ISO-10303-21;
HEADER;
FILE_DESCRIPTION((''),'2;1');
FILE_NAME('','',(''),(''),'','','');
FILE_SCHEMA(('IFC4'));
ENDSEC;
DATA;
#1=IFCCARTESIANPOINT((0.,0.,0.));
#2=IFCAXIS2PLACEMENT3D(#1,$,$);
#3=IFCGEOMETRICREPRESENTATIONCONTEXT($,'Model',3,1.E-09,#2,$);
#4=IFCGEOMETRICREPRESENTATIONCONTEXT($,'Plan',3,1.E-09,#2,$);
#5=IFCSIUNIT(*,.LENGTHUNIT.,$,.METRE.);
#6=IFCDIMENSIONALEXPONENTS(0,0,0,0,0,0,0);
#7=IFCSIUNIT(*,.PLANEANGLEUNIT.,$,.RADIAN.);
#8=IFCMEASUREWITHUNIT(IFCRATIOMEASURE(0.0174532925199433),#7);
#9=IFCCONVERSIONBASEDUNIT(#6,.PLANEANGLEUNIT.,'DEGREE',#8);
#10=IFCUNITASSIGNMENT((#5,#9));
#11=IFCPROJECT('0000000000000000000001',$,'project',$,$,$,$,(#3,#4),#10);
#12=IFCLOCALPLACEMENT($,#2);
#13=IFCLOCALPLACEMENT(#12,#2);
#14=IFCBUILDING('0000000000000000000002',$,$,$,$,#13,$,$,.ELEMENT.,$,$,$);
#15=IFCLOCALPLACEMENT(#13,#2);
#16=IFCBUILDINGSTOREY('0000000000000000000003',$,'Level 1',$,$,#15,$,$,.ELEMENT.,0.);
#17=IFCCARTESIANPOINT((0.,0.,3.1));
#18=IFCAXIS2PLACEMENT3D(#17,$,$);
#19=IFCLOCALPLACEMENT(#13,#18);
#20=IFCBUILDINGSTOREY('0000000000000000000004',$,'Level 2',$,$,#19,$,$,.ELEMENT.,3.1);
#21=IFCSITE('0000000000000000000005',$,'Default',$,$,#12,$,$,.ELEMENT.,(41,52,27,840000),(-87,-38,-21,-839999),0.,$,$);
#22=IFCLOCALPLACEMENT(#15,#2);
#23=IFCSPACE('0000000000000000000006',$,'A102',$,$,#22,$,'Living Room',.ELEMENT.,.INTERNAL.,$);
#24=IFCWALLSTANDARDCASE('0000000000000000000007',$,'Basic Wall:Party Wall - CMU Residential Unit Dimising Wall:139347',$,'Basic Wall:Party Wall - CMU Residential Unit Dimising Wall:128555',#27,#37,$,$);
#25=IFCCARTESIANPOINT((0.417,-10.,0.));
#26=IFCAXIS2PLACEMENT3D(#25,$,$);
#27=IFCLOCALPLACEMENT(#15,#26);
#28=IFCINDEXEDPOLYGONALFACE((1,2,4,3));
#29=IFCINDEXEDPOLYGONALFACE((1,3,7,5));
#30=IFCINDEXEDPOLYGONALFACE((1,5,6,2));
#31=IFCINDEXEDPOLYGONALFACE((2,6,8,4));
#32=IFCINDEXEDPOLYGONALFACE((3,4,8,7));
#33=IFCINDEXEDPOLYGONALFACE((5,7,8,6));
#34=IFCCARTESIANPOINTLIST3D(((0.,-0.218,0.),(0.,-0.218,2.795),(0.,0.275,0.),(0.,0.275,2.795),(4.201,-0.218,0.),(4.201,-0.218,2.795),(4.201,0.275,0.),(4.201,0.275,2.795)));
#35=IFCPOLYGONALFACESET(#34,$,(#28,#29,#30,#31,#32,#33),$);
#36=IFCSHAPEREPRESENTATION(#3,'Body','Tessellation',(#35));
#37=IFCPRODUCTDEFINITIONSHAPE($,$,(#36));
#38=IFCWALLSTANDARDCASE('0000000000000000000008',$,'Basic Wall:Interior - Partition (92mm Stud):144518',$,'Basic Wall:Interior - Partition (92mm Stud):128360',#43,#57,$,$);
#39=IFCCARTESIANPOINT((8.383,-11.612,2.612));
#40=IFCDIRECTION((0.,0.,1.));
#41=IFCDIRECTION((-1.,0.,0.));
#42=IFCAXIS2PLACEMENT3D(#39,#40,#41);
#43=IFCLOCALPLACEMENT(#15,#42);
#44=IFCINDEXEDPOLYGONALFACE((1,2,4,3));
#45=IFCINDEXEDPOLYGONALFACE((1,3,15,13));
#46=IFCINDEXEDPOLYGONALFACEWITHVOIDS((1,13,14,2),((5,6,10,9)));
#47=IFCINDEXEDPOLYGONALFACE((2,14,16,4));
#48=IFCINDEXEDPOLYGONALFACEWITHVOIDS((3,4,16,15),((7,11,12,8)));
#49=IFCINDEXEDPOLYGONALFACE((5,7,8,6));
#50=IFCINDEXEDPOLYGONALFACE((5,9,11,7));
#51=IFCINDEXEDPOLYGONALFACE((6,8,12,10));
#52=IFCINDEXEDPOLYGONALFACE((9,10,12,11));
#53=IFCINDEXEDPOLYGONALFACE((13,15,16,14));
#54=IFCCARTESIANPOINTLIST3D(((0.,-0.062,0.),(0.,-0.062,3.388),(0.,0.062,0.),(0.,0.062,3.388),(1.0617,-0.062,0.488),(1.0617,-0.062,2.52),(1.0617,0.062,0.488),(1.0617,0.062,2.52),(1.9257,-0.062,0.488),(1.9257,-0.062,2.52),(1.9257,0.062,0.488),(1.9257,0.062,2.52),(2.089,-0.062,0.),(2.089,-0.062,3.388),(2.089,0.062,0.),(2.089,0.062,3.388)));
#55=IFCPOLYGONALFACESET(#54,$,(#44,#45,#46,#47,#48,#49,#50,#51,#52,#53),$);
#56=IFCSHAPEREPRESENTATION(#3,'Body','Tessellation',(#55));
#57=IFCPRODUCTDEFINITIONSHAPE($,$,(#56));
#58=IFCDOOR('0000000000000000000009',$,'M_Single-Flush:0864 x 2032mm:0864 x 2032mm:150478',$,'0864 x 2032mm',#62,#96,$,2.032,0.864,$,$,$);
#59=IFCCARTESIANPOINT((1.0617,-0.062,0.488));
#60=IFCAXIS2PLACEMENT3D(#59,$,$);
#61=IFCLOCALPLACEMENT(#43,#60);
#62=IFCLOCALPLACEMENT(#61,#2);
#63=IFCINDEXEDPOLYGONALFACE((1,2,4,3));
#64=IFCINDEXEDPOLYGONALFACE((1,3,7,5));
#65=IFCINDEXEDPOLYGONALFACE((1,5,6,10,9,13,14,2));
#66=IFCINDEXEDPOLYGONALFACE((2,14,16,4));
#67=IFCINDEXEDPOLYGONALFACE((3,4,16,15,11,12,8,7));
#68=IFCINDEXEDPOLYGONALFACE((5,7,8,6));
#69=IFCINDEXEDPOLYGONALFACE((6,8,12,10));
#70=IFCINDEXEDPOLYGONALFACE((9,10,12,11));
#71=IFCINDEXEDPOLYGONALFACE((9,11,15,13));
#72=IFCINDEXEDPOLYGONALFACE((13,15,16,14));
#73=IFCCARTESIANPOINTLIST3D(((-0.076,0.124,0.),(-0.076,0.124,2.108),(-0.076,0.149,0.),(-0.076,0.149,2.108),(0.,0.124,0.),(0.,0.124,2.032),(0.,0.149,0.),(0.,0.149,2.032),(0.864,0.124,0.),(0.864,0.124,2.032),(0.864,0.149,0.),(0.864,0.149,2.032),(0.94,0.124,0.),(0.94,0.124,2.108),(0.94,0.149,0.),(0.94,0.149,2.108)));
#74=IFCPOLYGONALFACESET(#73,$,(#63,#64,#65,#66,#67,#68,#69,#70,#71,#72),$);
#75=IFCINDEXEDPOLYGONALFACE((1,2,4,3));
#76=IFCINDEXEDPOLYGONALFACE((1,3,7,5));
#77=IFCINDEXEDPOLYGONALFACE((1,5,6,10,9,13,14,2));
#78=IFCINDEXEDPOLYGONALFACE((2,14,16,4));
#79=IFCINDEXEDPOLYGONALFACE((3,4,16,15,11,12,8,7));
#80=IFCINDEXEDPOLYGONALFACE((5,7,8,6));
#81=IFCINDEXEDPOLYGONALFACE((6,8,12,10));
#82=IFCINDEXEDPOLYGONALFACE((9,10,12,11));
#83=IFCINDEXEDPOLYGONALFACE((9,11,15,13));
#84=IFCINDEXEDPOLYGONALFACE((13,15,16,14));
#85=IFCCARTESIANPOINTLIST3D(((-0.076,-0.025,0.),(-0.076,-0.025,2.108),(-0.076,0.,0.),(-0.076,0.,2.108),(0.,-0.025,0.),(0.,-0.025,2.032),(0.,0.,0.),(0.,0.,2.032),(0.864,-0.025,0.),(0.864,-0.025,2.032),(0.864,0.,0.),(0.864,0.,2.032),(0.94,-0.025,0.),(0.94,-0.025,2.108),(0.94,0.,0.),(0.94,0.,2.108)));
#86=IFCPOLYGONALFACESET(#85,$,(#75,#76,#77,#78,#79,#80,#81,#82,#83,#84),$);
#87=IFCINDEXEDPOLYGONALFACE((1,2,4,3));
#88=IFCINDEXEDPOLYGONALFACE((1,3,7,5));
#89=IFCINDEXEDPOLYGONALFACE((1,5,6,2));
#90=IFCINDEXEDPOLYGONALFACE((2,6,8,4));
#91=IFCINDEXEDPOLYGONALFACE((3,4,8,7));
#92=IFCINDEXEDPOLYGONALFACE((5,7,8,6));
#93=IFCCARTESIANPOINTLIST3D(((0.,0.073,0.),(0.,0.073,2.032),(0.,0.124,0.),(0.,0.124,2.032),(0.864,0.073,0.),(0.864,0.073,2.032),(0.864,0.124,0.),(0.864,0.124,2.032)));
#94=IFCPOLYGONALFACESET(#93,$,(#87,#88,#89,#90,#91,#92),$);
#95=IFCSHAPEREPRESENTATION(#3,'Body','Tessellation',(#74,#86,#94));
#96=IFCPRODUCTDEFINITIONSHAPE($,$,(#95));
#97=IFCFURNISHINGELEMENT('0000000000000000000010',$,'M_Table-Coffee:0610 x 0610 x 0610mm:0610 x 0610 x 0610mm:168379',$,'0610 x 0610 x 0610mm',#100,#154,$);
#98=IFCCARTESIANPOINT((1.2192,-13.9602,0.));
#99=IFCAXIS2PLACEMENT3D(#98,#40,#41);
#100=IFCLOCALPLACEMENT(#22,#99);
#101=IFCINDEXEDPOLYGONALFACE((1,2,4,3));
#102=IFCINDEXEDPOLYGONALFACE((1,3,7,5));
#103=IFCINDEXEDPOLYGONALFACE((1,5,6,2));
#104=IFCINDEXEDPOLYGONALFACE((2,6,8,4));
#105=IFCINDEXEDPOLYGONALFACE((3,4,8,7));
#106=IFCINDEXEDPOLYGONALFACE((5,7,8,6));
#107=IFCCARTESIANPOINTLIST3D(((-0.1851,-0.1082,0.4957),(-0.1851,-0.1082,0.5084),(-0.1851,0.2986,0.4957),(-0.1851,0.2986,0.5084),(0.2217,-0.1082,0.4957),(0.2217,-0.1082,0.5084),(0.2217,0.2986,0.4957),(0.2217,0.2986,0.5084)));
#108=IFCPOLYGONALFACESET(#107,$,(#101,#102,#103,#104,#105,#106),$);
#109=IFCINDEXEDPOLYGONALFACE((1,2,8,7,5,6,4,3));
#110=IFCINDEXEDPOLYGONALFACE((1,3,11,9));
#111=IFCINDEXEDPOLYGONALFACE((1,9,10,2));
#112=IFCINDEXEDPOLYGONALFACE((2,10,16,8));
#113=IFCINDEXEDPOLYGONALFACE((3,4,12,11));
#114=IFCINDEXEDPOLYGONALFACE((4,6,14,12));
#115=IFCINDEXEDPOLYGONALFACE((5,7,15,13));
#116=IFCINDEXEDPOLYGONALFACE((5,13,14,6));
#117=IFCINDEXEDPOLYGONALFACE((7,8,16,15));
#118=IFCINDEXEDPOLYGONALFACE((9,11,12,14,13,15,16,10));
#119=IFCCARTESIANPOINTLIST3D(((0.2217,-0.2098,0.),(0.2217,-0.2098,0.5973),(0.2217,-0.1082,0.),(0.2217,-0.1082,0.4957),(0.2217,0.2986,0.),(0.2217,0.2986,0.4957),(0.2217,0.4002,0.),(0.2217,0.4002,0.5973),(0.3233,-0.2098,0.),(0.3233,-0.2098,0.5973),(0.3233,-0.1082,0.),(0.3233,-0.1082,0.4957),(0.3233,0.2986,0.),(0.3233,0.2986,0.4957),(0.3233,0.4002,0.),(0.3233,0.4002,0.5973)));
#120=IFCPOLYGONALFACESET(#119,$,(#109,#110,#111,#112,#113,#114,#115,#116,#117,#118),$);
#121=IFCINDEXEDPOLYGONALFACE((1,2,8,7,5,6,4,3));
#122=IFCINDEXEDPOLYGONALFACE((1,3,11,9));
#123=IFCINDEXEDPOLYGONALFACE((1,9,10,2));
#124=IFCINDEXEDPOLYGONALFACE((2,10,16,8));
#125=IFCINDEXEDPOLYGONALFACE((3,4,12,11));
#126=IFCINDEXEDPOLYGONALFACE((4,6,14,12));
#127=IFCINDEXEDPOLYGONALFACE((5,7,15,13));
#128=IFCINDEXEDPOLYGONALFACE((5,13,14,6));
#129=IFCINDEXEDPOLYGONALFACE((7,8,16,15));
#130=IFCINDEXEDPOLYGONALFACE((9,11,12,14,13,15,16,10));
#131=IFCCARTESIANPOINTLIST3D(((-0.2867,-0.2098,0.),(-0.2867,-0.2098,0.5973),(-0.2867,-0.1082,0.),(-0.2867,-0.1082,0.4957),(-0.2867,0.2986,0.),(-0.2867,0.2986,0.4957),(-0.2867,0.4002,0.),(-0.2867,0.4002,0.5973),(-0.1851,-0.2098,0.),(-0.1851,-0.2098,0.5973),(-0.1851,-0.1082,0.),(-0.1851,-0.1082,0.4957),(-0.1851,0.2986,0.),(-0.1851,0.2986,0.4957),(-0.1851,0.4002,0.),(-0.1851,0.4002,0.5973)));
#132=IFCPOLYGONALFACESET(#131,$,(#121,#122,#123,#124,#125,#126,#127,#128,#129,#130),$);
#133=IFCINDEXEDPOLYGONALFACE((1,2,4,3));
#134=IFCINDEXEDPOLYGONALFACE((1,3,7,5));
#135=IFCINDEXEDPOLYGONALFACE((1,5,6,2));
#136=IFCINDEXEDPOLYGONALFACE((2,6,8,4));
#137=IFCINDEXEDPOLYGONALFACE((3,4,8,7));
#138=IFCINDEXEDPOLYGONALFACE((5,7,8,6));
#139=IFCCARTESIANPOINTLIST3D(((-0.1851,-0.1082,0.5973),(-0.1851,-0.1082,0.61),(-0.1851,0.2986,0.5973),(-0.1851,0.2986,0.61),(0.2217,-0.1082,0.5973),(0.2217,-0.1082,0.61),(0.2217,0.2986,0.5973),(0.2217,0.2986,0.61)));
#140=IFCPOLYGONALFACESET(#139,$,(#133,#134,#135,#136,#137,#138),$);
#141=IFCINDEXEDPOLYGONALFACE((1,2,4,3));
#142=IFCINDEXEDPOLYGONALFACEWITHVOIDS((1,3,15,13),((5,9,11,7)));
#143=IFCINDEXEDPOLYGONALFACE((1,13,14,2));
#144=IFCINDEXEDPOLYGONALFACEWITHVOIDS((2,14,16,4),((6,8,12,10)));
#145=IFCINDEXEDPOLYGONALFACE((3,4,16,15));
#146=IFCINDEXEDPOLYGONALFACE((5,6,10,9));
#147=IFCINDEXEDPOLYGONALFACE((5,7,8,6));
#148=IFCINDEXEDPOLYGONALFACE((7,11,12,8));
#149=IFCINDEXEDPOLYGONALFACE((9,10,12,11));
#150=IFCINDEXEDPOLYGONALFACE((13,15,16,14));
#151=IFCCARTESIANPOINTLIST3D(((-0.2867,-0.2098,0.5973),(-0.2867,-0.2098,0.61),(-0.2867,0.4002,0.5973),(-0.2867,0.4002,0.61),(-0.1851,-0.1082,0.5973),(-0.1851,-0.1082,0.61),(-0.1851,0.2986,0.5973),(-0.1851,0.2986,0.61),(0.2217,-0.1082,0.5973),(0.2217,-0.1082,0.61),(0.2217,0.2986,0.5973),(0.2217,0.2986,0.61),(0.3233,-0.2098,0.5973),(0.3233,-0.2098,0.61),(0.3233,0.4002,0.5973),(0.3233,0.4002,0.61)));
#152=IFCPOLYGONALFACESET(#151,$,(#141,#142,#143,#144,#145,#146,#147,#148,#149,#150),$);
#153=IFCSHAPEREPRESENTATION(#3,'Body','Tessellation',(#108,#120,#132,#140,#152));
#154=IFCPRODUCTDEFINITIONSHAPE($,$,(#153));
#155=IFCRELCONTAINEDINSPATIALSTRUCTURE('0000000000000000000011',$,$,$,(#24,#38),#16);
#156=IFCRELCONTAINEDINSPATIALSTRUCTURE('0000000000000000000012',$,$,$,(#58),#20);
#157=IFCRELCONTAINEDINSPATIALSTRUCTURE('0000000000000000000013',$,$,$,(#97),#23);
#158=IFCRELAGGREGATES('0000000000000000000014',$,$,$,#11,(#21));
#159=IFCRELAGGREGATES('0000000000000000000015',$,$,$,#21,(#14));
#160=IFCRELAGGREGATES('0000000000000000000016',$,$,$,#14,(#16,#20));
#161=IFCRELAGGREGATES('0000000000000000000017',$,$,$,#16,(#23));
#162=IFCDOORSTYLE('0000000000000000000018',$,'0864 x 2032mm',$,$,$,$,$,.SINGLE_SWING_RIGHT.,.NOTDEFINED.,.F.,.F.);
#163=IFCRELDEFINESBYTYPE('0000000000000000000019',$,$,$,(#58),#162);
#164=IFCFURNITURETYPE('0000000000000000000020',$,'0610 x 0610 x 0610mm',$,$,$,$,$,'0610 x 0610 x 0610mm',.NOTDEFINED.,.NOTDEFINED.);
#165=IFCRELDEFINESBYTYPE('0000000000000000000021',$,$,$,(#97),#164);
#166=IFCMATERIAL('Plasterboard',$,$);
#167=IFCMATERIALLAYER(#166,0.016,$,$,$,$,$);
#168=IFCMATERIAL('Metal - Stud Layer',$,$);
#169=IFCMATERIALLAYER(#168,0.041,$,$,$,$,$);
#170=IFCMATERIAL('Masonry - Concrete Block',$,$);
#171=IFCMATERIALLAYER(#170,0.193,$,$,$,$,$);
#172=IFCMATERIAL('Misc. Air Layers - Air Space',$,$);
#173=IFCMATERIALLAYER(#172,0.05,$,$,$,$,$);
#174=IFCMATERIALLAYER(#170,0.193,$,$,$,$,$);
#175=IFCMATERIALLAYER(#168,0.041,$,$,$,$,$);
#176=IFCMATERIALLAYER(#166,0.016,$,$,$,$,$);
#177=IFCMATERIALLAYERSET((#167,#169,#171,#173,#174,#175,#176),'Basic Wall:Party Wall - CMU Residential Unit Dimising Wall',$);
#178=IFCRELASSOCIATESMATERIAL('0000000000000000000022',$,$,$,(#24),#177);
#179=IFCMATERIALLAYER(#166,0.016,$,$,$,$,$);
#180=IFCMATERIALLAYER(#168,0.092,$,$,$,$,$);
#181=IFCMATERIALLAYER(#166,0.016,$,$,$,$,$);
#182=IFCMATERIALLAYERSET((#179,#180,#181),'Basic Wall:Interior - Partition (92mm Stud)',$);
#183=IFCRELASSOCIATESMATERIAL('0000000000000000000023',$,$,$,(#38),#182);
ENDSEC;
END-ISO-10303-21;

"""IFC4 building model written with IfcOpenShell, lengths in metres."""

from ifc_helpers import new_model, entity, si_unit, converted_unit, frame, frame_2d, origin, origin_2d_with_axis, place, context, project, spatial, polyline, rectangle, outline, extrude, clip, bounded_halfspace, source, transform, mapped, material, layer, layer_set, layer_usage, type_object, type_shapes, element, fill, save


model = new_model("IFC4")

# Units and contexts
model_context = context("Model", 3, precision=1e-09, world=origin())
plan_context = context("Plan", 3, precision=1e-09, world=origin())
ifc_project = project(units=[si_unit("LENGTHUNIT", "METRE"), converted_unit("PLANEANGLEUNIT", "DEGREE", entity("IfcRatioMeasure", 0.0174532925199433), si_unit("PLANEANGLEUNIT", "RADIAN"), dimensions=[0, 0, 0, 0, 0, 0, 0])], contexts=[model_context, plan_context])

# Site, building, storey
site_placement = place(None, origin())
site = spatial("IfcSite", under=ifc_project, at=site_placement, Name="Default", CompositionType="ELEMENT", RefLatitude=(41, 52, 27, 840000), RefLongitude=(-87, -38, -21, -839999), RefElevation=0.0)
building_placement = place(site_placement, origin())
building = spatial("IfcBuilding", under=site, at=building_placement, CompositionType="ELEMENT")
storey_1_placement = place(building_placement, origin())
storey_1 = spatial("IfcBuildingStorey", under=building, at=storey_1_placement, Name="Level 1", CompositionType="ELEMENT", Elevation=0.0)

# Shared definitions
ifc_material_1 = material(Name="Metal - Stud Layer")
ifc_material_2 = material(Name="Plasterboard")
ifc_layer_1 = layer(ifc_material_2, 0.016)
ifc_layer_2 = layer(ifc_material_1, 0.041)
ifc_material_3 = material(Name="Masonry - Concrete Block")
ifc_layer_3 = layer(ifc_material_3, 0.193)
ifc_material_4 = material(Name="Misc. Air Layers - Air Space")
ifc_layer_4 = layer(ifc_material_4, 0.05)
ifc_layer_5 = layer(ifc_material_3, 0.193)
ifc_layer_6 = layer(ifc_material_1, 0.041)
ifc_layer_7 = layer(ifc_material_2, 0.016)
ifc_layer_set_1 = layer_set([ifc_layer_1, ifc_layer_2, ifc_layer_3, ifc_layer_4, ifc_layer_5, ifc_layer_6, ifc_layer_7], Name="Basic Wall:Party Wall - CMU Residential Unit Dimising Wall")

# Wall
ifc_layer_8 = layer(ifc_material_2, 0.016)
ifc_layer_9 = layer(ifc_material_1, 0.092)
ifc_layer_10 = layer(ifc_material_2, 0.016)
ifc_layer_set_2 = layer_set([ifc_layer_8, ifc_layer_9, ifc_layer_10], Name="Basic Wall:Interior - Partition (92mm Stud)")
ifc_layer_usage_1 = layer_usage(ifc_layer_set_1, "AXIS2", "NEGATIVE", 0.275)
wall_1_placement = place(storey_1_placement, frame((0.417, -10.0, 0.0)))
element("IfcWallStandardCase", 1, at=wall_1_placement, inside=storey_1, material=ifc_layer_usage_1, Name="Basic Wall:Party Wall - CMU Residential Unit Dimising Wall:139347", ObjectType="Basic Wall:Party Wall - CMU Residential Unit Dimising Wall:128555", context=model_context, shape_type="Clipping", body=[
    clip(clip(extrude(rectangle(XDim=4.201, YDim=0.55, at=frame_2d((2.1005, 0.0), x_axis=(-1.0, 0.0))), origin(), (0.0, 0.0, 1.0), 2.795), bounded_halfspace(frame((0.0, -0.218, 0.0), z_axis=(0.0, 1.0, 0.0), x_axis=(-1.0, 0.0, 0.0)), True, frame((0.0, -0.218, 0.0), z_axis=(0.0, 1.0, 0.0), x_axis=(-1.0, 0.0, 0.0)), polyline([(0.0, 0.0), (0.0, 2.795), (-4.201, 2.795), (-4.201, 0.0), (0.0, 0.0)]))), bounded_halfspace(frame((4.201, 0.275, 0.0), z_axis=(-1.0, 0.0, 0.0), x_axis=(0.0, -1.0, 0.0)), True, frame((4.201, 0.275, 0.0), z_axis=(-1.0, 0.0, 0.0), x_axis=(0.0, -1.0, 0.0)), polyline([(0.0, 0.0), (0.493, 0.0), (0.493, 2.795), (0.0, 2.795), (0.0, 0.0)]))),
])

# Wall, opening
ifc_layer_usage_2 = layer_usage(ifc_layer_set_2, "AXIS2", "NEGATIVE", 0.062)
wall_2_placement = place(storey_1_placement, frame((8.383, -11.612, 2.612), z_axis=(0.0, 0.0, 1.0), x_axis=(-1.0, 0.0, 0.0)))
wall_2 = element("IfcWallStandardCase", 2, at=wall_2_placement, inside=storey_1, material=ifc_layer_usage_2, Name="Basic Wall:Interior - Partition (92mm Stud):144518", ObjectType="Basic Wall:Interior - Partition (92mm Stud):128360", context=model_context, shape_type="SweptSolid", body=[
    extrude(rectangle(XDim=2.089, YDim=0.124, at=frame_2d((1.0445, 0.0), x_axis=(-1.0, 0.0))), origin(), (0.0, 0.0, 1.0), 3.388),
])
opening_1_placement = place(wall_2_placement, frame((1.0617, -0.062, 0.488)))
opening_1 = element("IfcOpeningElement", 3, at=opening_1_placement, cuts=wall_2, ObjectType="Opening", context=model_context, shape_type="SweptSolid", body=[
    extrude(rectangle(XDim=0.864, YDim=2.032, at=frame_2d((1.016, 0.432), x_axis=(0.0, 1.0))), frame((0.0, 0.0, 0.0), z_axis=(0.0, 1.0, 0.0), x_axis=(0.0, 0.0, 1.0)), (0.0, 0.0, 1.0), 0.124),
])

# Shared definitions
storey_2_placement = place(building_placement, frame((0.0, 0.0, 3.1)))
storey_2 = spatial("IfcBuildingStorey", under=building, at=storey_2_placement, Name="Level 2", CompositionType="ELEMENT", Elevation=3.1)

# Door
door_style_1 = type_object("IfcDoorStyle", Name="0864 x 2032mm", ConstructionType="NOTDEFINED", OperationType="SINGLE_SWING_RIGHT", ParameterTakesPrecedence=False, Sizeable=False)
shared_shape_1 = source(origin(), model_context, "Body", "SweptSolid", [
    extrude(outline(polyline([(-0.508, -1.073), (0.508, -1.073), (0.508, 1.035), (0.432, 1.035), (0.432, -0.997), (-0.432, -0.997), (-0.432, 1.035), (-0.508, 1.035), (-0.508, -1.073)])), frame((0.432, 0.124, 1.035), z_axis=(0.0, 1.0, 0.0), x_axis=(1.0, 0.0, 0.0)), (0.0, 0.0, 1.0), 0.025),
    extrude(outline(polyline([(-1.073, -0.508), (1.035, -0.508), (1.035, -0.432), (-0.997, -0.432), (-0.997, 0.432), (1.035, 0.432), (1.035, 0.508), (-1.073, 0.508), (-1.073, -0.508)])), frame((0.432, -0.025, 1.035), z_axis=(0.0, 1.0, 0.0), x_axis=(0.0, 0.0, -1.0)), (0.0, 0.0, 1.0), 0.025),
    extrude(rectangle(XDim=0.051, YDim=0.864, at=origin_2d_with_axis()), frame((0.432, 0.0985, 0.0), z_axis=(0.0, 0.0, 1.0), x_axis=(0.0, 1.0, 0.0)), (0.0, 0.0, 1.0), 2.032),
])
type_shapes(door_style_1, [shared_shape_1])
door_1_placement = place(opening_1_placement, origin())
door_1 = element("IfcDoor", 4, at=door_1_placement, inside=storey_2, type_object=door_style_1, Name="M_Single-Flush:0864 x 2032mm:0864 x 2032mm:150478", ObjectType="0864 x 2032mm", OverallHeight=2.032, OverallWidth=0.864, context=model_context, shape_type="MappedRepresentation", body=[
    mapped(shared_shape_1, transform((0.0, 0.0, 0.0), scale=1.0)),
])
fill(opening_1, door_1)

# Shared definitions
space_1_placement = place(storey_1_placement, origin())
space_1 = spatial("IfcSpace", under=storey_1, at=space_1_placement, Name="A102", LongName="Living Room", CompositionType="ELEMENT", PredefinedType="INTERNAL")

# Furnishing element
furniture_type_1 = type_object("IfcFurnitureType", Name="0610 x 0610 x 0610mm", ElementType="0610 x 0610 x 0610mm", AssemblyPlace="NOTDEFINED")
shared_shape_2 = source(origin(), model_context, "Body", "SweptSolid", [
    extrude(rectangle(XDim=0.4068, YDim=0.4068, at=origin_2d_with_axis()), frame((0.0183, 0.0952, 0.4957), z_axis=(0.0, 0.0, 1.0), x_axis=(-1.0, 0.0, 0.0)), (0.0, 0.0, 1.0), 0.0127),
    extrude(outline(polyline([(-0.2732, -0.305), (0.324, -0.305), (0.324, 0.305), (-0.2732, 0.305), (-0.2732, 0.2034), (0.2225, 0.2034), (0.2225, -0.2034), (-0.2732, -0.2034), (-0.2732, -0.305)])), frame((0.2217, 0.0952, 0.2732), z_axis=(1.0, 0.0, 0.0), x_axis=(0.0, 0.0, 1.0)), (0.0, 0.0, 1.0), 0.1016),
    extrude(outline(polyline([(-0.305, -0.3241), (0.305, -0.3241), (0.305, 0.2733), (0.2034, 0.2733), (0.2034, -0.2224), (-0.2034, -0.2224), (-0.2034, 0.2733), (-0.305, 0.2733), (-0.305, -0.3241)])), frame((-0.2867, 0.0952, 0.2733), z_axis=(1.0, 0.0, 0.0), x_axis=(0.0, -1.0, 0.0)), (0.0, 0.0, 1.0), 0.1016),
    extrude(rectangle(XDim=0.4068, YDim=0.4068, at=origin_2d_with_axis()), frame((0.0183, 0.0952, 0.5973), z_axis=(0.0, 0.0, 1.0), x_axis=(-1.0, 0.0, 0.0)), (0.0, 0.0, 1.0), 0.0127),
    extrude(outline(polyline([(-0.305, -0.305), (0.305, -0.305), (0.305, 0.305), (-0.305, 0.305), (-0.305, -0.305)]), holes=[polyline([(-0.2034, -0.2034), (-0.2034, 0.2034), (0.2034, 0.2034), (0.2034, -0.2034), (-0.2034, -0.2034)])]), frame((0.0183, 0.0952, 0.5973), z_axis=(0.0, 0.0, 1.0), x_axis=(-1.0, 0.0, 0.0)), (0.0, 0.0, 1.0), 0.0127),
])
type_shapes(furniture_type_1, [shared_shape_2])
for number, where, z_axis, x_axis, name in (
    (5, (1.2192, -13.9602, 0.0), (0.0, 0.0, 1.0), (-1.0, 0.0, 0.0), "M_Table-Coffee:0610 x 0610 x 0610mm:0610 x 0610 x 0610mm:168379"),
):
    element("IfcFurnishingElement", number, at=place(space_1_placement, frame(where, z_axis=z_axis, x_axis=x_axis)), inside=space_1, type_object=furniture_type_1, Name=name, ObjectType="0610 x 0610 x 0610mm", context=model_context, shape_type="MappedRepresentation", body=[
        mapped(shared_shape_2, transform((0.0, 0.0, 0.0), scale=1.0)),
    ])

save(model, "model.ifc")
